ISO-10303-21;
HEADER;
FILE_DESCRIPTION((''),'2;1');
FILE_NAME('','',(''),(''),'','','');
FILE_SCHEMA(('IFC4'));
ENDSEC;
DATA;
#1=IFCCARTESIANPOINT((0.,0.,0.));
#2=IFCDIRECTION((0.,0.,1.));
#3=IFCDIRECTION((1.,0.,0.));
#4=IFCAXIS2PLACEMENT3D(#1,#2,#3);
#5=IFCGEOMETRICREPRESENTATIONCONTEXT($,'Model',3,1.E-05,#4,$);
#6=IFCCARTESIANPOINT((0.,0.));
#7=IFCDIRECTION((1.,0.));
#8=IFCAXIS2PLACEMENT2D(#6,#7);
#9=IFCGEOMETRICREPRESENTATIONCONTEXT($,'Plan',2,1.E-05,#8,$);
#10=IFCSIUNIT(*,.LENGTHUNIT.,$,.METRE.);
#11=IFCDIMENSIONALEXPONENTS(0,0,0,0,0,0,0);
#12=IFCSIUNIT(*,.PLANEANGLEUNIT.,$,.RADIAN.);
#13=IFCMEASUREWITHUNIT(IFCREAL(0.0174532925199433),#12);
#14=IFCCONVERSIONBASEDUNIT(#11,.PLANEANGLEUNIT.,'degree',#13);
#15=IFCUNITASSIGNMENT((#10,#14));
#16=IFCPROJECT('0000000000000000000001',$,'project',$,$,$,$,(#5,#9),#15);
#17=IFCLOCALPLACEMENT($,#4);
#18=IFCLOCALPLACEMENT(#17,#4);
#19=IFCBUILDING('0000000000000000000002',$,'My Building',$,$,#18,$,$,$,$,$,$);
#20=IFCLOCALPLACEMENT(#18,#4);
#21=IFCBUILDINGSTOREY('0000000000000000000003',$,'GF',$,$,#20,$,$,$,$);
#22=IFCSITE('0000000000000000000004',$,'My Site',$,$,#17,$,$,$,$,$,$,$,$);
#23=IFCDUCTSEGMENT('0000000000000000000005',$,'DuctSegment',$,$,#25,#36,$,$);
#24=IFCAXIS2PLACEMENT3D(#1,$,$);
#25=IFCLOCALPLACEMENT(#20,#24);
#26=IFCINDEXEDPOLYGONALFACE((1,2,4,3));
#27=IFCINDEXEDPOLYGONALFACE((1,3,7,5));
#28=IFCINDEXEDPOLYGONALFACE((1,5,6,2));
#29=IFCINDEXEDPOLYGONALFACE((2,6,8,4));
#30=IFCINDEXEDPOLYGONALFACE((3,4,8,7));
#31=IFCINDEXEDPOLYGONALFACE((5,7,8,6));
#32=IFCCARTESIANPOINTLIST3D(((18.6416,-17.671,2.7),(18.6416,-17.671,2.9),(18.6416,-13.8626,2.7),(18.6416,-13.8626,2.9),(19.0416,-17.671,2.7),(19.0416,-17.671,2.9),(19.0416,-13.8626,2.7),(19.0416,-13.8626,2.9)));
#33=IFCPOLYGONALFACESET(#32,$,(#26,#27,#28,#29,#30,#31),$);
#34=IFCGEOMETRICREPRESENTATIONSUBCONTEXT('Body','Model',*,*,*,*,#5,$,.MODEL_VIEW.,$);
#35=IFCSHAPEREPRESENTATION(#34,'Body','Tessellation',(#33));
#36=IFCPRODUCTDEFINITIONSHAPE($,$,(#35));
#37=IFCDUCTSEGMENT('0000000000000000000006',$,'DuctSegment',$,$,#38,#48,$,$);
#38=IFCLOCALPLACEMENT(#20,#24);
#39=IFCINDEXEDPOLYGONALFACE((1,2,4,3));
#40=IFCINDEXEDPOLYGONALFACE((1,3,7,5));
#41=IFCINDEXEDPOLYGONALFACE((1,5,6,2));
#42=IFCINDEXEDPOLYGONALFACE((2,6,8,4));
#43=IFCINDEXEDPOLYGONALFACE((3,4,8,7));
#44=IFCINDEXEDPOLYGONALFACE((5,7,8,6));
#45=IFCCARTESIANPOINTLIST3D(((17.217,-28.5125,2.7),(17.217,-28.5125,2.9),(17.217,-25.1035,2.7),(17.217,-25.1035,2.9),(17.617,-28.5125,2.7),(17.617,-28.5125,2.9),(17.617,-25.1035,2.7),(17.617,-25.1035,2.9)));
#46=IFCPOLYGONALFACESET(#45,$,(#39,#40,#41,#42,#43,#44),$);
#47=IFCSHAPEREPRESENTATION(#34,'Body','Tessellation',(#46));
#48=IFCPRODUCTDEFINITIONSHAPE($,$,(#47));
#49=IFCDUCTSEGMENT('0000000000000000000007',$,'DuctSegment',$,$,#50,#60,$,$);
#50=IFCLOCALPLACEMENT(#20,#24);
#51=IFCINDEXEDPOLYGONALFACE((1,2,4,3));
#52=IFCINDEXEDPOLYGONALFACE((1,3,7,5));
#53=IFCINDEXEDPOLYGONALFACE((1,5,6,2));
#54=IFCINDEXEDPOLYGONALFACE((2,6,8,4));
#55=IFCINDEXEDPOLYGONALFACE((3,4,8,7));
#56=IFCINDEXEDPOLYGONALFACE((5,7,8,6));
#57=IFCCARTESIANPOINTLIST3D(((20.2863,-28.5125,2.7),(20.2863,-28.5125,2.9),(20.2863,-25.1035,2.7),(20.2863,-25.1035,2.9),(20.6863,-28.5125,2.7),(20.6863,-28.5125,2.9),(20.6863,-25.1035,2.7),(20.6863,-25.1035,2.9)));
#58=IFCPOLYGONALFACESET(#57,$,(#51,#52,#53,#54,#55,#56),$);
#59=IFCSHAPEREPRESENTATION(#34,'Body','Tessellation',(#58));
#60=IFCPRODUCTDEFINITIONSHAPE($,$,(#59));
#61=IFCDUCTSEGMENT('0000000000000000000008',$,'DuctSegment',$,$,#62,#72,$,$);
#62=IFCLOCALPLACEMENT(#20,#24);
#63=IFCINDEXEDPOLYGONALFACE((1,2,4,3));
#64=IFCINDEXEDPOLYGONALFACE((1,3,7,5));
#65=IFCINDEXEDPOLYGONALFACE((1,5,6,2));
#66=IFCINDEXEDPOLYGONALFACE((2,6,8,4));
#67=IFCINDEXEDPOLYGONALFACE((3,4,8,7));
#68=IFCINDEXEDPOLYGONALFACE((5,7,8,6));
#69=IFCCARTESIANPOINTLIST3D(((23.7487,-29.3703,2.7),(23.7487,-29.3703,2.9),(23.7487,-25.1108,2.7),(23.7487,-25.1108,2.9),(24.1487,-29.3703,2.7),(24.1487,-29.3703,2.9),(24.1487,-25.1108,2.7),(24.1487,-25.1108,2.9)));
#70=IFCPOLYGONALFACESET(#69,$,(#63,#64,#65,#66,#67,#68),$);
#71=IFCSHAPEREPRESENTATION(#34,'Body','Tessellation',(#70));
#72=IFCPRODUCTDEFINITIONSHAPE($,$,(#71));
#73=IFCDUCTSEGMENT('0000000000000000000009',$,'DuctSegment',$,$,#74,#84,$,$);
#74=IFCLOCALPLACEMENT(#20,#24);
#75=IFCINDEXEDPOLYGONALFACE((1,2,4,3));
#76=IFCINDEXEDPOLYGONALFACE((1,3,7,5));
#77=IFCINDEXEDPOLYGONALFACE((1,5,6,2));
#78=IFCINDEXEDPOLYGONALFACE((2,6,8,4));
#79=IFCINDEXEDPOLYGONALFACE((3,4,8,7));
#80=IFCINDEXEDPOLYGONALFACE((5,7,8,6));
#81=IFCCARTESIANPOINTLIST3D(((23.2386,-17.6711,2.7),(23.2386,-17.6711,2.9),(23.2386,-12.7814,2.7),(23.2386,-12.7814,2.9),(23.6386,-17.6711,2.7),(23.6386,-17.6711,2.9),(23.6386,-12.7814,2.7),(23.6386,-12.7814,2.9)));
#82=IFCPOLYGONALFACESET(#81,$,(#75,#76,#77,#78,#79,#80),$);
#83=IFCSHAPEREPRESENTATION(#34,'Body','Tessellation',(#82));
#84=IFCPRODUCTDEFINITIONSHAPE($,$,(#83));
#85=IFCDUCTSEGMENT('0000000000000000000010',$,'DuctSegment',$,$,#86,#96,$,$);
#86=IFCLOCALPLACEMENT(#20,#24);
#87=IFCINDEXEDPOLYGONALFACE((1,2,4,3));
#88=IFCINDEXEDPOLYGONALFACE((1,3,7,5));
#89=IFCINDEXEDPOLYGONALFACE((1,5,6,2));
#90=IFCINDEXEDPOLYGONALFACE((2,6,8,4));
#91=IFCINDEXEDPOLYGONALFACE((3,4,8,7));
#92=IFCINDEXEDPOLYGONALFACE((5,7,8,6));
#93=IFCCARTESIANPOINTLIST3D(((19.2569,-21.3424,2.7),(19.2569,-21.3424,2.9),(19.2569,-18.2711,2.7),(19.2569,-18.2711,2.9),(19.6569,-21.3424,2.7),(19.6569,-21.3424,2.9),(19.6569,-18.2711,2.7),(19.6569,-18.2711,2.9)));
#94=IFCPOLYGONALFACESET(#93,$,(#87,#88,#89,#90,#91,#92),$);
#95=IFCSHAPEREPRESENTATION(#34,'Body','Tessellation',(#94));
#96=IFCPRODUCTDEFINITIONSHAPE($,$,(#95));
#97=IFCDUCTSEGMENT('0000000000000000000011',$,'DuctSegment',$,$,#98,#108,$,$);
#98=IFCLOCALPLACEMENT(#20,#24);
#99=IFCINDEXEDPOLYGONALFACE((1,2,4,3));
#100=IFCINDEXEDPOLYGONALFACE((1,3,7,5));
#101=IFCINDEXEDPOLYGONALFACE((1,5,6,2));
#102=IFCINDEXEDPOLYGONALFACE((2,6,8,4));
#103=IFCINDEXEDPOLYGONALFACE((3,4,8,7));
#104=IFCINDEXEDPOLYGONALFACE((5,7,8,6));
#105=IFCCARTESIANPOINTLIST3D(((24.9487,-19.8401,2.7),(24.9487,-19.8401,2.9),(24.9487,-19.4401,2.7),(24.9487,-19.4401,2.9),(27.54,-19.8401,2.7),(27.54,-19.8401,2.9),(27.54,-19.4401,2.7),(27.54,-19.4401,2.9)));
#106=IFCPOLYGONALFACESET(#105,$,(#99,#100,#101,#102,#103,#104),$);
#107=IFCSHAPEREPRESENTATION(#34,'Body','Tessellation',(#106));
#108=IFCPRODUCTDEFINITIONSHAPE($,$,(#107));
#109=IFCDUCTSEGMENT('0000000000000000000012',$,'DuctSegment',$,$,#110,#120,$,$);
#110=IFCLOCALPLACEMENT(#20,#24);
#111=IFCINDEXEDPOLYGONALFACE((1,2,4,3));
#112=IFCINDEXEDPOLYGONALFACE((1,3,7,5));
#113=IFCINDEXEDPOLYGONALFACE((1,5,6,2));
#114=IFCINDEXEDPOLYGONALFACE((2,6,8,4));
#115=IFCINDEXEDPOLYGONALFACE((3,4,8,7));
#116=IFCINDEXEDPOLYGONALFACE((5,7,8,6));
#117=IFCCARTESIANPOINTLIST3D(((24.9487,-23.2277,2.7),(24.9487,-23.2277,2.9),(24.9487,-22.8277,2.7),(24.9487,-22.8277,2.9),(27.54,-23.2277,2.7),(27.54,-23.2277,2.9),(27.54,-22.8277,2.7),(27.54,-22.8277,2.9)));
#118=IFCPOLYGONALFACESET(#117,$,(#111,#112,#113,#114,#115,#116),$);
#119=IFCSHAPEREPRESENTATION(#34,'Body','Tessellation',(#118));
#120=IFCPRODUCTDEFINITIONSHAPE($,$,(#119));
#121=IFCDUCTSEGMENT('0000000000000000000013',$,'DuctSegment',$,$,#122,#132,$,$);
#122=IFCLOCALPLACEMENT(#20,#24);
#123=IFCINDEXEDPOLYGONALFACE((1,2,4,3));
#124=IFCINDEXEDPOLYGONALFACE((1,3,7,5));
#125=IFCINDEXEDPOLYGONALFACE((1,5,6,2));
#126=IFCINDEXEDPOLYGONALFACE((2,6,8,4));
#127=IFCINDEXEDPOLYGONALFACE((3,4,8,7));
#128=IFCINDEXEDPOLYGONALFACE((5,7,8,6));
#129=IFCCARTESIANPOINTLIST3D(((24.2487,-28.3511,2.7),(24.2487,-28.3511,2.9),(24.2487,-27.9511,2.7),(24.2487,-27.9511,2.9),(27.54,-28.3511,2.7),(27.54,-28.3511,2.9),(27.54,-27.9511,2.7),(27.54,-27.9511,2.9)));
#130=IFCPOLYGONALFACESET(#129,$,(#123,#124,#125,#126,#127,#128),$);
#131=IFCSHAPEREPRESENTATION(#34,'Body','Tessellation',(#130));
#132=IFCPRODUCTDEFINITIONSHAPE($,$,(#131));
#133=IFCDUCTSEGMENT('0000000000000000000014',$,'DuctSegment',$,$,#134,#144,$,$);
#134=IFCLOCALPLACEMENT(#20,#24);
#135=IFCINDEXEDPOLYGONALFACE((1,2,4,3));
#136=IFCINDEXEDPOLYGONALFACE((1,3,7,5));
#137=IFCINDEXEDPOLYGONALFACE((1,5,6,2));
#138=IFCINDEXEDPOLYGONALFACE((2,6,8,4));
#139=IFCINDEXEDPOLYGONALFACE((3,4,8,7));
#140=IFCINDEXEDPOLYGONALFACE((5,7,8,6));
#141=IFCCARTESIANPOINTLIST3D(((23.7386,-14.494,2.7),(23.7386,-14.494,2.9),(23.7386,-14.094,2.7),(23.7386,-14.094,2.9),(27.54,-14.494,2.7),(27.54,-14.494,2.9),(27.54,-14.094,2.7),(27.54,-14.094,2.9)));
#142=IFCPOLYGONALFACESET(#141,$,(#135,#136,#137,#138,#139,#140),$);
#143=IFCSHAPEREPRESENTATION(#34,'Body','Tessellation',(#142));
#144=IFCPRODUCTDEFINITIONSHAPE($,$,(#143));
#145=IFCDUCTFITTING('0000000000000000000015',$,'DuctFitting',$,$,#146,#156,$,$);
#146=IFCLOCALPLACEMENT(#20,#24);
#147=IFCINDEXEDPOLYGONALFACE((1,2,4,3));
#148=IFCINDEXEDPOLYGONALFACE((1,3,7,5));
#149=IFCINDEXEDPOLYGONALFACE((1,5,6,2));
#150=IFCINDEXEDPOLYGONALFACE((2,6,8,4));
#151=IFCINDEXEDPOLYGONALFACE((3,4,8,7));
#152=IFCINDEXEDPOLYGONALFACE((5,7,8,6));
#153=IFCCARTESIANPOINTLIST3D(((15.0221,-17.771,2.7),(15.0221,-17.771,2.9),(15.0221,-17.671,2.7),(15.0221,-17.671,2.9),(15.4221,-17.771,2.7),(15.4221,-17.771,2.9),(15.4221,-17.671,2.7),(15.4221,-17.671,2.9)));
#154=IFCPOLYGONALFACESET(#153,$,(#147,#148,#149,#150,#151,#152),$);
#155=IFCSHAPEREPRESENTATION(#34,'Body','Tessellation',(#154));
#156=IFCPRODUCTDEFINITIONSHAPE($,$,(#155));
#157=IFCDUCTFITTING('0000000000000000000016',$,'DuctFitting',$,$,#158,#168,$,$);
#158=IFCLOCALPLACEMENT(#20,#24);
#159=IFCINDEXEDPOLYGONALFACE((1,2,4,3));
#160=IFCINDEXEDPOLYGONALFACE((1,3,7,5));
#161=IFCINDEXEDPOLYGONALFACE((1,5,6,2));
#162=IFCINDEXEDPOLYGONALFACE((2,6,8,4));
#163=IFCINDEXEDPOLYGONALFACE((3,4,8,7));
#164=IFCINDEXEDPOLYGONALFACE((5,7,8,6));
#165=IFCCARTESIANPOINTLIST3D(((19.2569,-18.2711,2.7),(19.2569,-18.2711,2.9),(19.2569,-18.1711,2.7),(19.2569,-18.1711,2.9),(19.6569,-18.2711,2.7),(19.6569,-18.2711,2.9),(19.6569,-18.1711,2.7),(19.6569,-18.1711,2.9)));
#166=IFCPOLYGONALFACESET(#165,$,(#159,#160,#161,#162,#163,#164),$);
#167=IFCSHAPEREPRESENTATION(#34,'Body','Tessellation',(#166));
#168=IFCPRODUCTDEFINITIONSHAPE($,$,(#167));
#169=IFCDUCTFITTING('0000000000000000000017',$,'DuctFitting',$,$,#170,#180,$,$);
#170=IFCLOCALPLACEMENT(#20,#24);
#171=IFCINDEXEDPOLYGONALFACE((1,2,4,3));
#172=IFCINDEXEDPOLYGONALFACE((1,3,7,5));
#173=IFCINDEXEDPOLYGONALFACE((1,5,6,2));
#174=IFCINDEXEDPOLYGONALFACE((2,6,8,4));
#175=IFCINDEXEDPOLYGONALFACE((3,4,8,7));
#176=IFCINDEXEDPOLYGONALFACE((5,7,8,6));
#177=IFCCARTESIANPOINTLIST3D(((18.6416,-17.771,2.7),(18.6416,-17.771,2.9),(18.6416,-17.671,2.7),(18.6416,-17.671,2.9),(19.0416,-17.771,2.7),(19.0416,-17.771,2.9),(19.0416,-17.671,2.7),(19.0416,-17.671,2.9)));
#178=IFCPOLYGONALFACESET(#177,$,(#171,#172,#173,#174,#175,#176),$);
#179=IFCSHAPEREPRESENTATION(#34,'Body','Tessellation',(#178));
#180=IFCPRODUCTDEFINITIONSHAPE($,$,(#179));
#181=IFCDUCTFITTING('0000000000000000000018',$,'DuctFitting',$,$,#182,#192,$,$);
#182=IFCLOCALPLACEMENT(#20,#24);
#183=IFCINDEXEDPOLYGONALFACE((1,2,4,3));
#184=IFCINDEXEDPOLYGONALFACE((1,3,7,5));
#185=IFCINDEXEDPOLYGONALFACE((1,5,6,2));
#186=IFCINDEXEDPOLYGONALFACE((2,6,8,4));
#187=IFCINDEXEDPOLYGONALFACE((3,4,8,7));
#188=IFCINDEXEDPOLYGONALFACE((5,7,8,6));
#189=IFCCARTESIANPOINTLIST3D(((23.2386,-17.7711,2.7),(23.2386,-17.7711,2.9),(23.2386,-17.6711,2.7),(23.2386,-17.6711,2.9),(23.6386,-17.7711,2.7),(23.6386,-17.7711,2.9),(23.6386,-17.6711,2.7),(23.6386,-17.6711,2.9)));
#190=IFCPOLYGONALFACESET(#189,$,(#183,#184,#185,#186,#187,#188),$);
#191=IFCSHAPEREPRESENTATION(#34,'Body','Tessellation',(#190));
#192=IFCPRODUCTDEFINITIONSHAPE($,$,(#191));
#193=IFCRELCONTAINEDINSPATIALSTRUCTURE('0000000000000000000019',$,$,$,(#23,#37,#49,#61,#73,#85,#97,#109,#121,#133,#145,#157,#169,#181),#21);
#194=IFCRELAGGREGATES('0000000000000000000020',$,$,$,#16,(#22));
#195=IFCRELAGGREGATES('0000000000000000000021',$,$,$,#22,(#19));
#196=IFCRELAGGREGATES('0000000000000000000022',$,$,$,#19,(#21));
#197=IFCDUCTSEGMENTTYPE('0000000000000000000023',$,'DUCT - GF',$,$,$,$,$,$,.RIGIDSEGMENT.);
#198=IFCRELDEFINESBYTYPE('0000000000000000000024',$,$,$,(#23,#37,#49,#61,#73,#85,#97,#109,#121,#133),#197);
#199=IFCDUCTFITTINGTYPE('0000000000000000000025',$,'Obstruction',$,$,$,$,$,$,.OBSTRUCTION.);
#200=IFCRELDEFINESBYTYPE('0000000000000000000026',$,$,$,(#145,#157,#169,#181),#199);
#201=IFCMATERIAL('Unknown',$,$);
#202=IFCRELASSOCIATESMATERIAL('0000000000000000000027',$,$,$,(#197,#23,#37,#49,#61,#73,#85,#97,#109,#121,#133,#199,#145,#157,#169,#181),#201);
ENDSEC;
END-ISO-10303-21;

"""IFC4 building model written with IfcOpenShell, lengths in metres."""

from ifc_helpers import new_model, entity, si_unit, converted_unit, frame, origin_with_axes, origin_2d_with_axis, place, context, subcontext, project, spatial, rectangle, extrude, material, material_profile, profile_set, profile_usage, type_object, element, save


model = new_model("IFC4")

# Units and contexts
model_context = context("Model", 3, precision=1e-05, world=origin_with_axes())
plan_context = context("Plan", 2, precision=1e-05, world=origin_2d_with_axis())
body_context_1 = subcontext(model_context, "Body", "Model", "MODEL_VIEW")
ifc_project = project(units=[si_unit("LENGTHUNIT", "METRE"), converted_unit("PLANEANGLEUNIT", "degree", entity("IfcReal", 0.0174532925199433), si_unit("PLANEANGLEUNIT", "RADIAN"), dimensions=[0, 0, 0, 0, 0, 0, 0])], contexts=[model_context, plan_context])

# Site, building, storey
site_placement = place(None, origin_with_axes())
site = spatial("IfcSite", under=ifc_project, at=site_placement, Name="My Site")
building_placement = place(site_placement, origin_with_axes())
building = spatial("IfcBuilding", under=site, at=building_placement, Name="My Building")
storey_placement = place(building_placement, origin_with_axes())
storey = spatial("IfcBuildingStorey", under=building, at=storey_placement, Name="GF")

# Shared definitions
ifc_material = material(Name="Unknown")

# Duct segments
ifc_material_profile_1 = material_profile(ifc_material, rectangle(XDim=0.4, YDim=0.2))
ifc_profile_set_1 = profile_set([ifc_material_profile_1])
duct_segment_type = type_object("IfcDuctSegmentType", Name="DUCT - GF", PredefinedType="RIGIDSEGMENT", material=ifc_profile_set_1)
ifc_profile_usage_1 = profile_usage(ifc_profile_set_1, cardinal=5)
duct_segment_1_placement = place(storey_placement, frame((18.8416, -13.8626, 2.8), z_axis=(0.0, -1.0, 0.0), x_axis=(1.0, 0.0, 0.0)))
element("IfcDuctSegment", 1, at=duct_segment_1_placement, inside=storey, type_object=duct_segment_type, material=ifc_profile_usage_1, Name="DuctSegment", context=body_context_1, shape_type="SweptSolid", body=[
    extrude(rectangle(XDim=0.4, YDim=0.2), origin_with_axes(), (0.0, 0.0, 1.0), 3.8084),
])
ifc_profile_usage_2 = profile_usage(ifc_profile_set_1, cardinal=5)
duct_segment_2_placement = place(storey_placement, frame((17.417, -28.5125, 2.8), z_axis=(0.0, 1.0, 0.0), x_axis=(-1.0, 0.0, 0.0)))
element("IfcDuctSegment", 2, at=duct_segment_2_placement, inside=storey, type_object=duct_segment_type, material=ifc_profile_usage_2, Name="DuctSegment", context=body_context_1, shape_type="SweptSolid", body=[
    extrude(rectangle(XDim=0.4, YDim=0.2), origin_with_axes(), (0.0, 0.0, 1.0), 3.409),
])
ifc_profile_usage_3 = profile_usage(ifc_profile_set_1, cardinal=5)
duct_segment_3_placement = place(storey_placement, frame((20.4863, -28.5125, 2.8), z_axis=(0.0, 1.0, 0.0), x_axis=(-1.0, 0.0, 0.0)))
element("IfcDuctSegment", 3, at=duct_segment_3_placement, inside=storey, type_object=duct_segment_type, material=ifc_profile_usage_3, Name="DuctSegment", context=body_context_1, shape_type="SweptSolid", body=[
    extrude(rectangle(XDim=0.4, YDim=0.2), origin_with_axes(), (0.0, 0.0, 1.0), 3.409),
])
ifc_profile_usage_4 = profile_usage(ifc_profile_set_1, cardinal=5)
duct_segment_4_placement = place(storey_placement, frame((23.9487, -29.3703, 2.8), z_axis=(0.0, 1.0, 0.0), x_axis=(-1.0, 0.0, 0.0)))
element("IfcDuctSegment", 4, at=duct_segment_4_placement, inside=storey, type_object=duct_segment_type, material=ifc_profile_usage_4, Name="DuctSegment", context=body_context_1, shape_type="SweptSolid", body=[
    extrude(rectangle(XDim=0.4, YDim=0.2), origin_with_axes(), (0.0, 0.0, 1.0), 4.2596),
])
ifc_profile_usage_5 = profile_usage(ifc_profile_set_1, cardinal=5)
duct_segment_5_placement = place(storey_placement, frame((23.4386, -12.7814, 2.8), z_axis=(0.0, -1.0, 0.0), x_axis=(1.0, 0.0, 0.0)))
element("IfcDuctSegment", 5, at=duct_segment_5_placement, inside=storey, type_object=duct_segment_type, material=ifc_profile_usage_5, Name="DuctSegment", context=body_context_1, shape_type="SweptSolid", body=[
    extrude(rectangle(XDim=0.4, YDim=0.2), origin_with_axes(), (0.0, 0.0, 1.0), 4.8897),
])
ifc_profile_usage_6 = profile_usage(ifc_profile_set_1, cardinal=5)
duct_segment_6_placement = place(storey_placement, frame((19.4569, -21.3424, 2.8), z_axis=(0.0, 1.0, 0.0), x_axis=(-1.0, 0.0, 0.0)))
element("IfcDuctSegment", 6, at=duct_segment_6_placement, inside=storey, type_object=duct_segment_type, material=ifc_profile_usage_6, Name="DuctSegment", context=body_context_1, shape_type="SweptSolid", body=[
    extrude(rectangle(XDim=0.4, YDim=0.2), origin_with_axes(), (0.0, 0.0, 1.0), 3.0713),
])
ifc_profile_usage_7 = profile_usage(ifc_profile_set_1, cardinal=5)
duct_segment_7_placement = place(storey_placement, frame((27.54, -19.6401, 2.8), z_axis=(-1.0, 0.0, 0.0), x_axis=(0.0, -1.0, 0.0)))
element("IfcDuctSegment", 7, at=duct_segment_7_placement, inside=storey, type_object=duct_segment_type, material=ifc_profile_usage_7, Name="DuctSegment", context=body_context_1, shape_type="SweptSolid", body=[
    extrude(rectangle(XDim=0.4, YDim=0.2), origin_with_axes(), (0.0, 0.0, 1.0), 2.5913),
])
ifc_profile_usage_8 = profile_usage(ifc_profile_set_1, cardinal=5)
duct_segment_8_placement = place(storey_placement, frame((27.54, -23.0277, 2.8), z_axis=(-1.0, 0.0, 0.0), x_axis=(0.0, -1.0, 0.0)))
element("IfcDuctSegment", 8, at=duct_segment_8_placement, inside=storey, type_object=duct_segment_type, material=ifc_profile_usage_8, Name="DuctSegment", context=body_context_1, shape_type="SweptSolid", body=[
    extrude(rectangle(XDim=0.4, YDim=0.2), origin_with_axes(), (0.0, 0.0, 1.0), 2.5913),
])
ifc_profile_usage_9 = profile_usage(ifc_profile_set_1, cardinal=5)
duct_segment_9_placement = place(storey_placement, frame((27.54, -28.1511, 2.8), z_axis=(-1.0, 0.0, 0.0), x_axis=(0.0, -1.0, 0.0)))
element("IfcDuctSegment", 9, at=duct_segment_9_placement, inside=storey, type_object=duct_segment_type, material=ifc_profile_usage_9, Name="DuctSegment", context=body_context_1, shape_type="SweptSolid", body=[
    extrude(rectangle(XDim=0.4, YDim=0.2), origin_with_axes(), (0.0, 0.0, 1.0), 3.2913),
])
ifc_profile_usage_10 = profile_usage(ifc_profile_set_1, cardinal=5)
duct_segment_10_placement = place(storey_placement, frame((27.54, -14.294, 2.8), z_axis=(-1.0, 0.0, 0.0), x_axis=(0.0, -1.0, 0.0)))
element("IfcDuctSegment", 10, at=duct_segment_10_placement, inside=storey, type_object=duct_segment_type, material=ifc_profile_usage_10, Name="DuctSegment", context=body_context_1, shape_type="SweptSolid", body=[
    extrude(rectangle(XDim=0.4, YDim=0.2), origin_with_axes(), (0.0, 0.0, 1.0), 3.8014),
])

# Duct fittings
ifc_material_profile_2 = material_profile(ifc_material, rectangle(XDim=0.4, YDim=0.2))
ifc_profile_set_2 = profile_set([ifc_material_profile_2])
ifc_profile_usage_11 = profile_usage(ifc_profile_set_2, cardinal=5)
duct_fitting_type = type_object("IfcDuctFittingType", Name="Obstruction", PredefinedType="OBSTRUCTION", material=ifc_profile_set_2)
duct_fitting_1_placement = place(storey_placement, frame((15.2221, -17.671, 2.8), z_axis=(0.0, -1.0, 0.0), x_axis=(1.0, 0.0, 0.0)))
element("IfcDuctFitting", 11, at=duct_fitting_1_placement, inside=storey, type_object=duct_fitting_type, material=ifc_profile_usage_11, Name="DuctFitting", context=body_context_1, shape_type="SweptSolid", body=[
    extrude(rectangle(XDim=0.4, YDim=0.2), origin_with_axes(), (0.0, 0.0, 1.0), 0.1),
])
ifc_profile_usage_12 = profile_usage(ifc_profile_set_2, cardinal=5)
duct_fitting_2_placement = place(storey_placement, frame((19.4569, -18.2711, 2.8), z_axis=(0.0, 1.0, 0.0), x_axis=(-1.0, 0.0, 0.0)))
element("IfcDuctFitting", 12, at=duct_fitting_2_placement, inside=storey, type_object=duct_fitting_type, material=ifc_profile_usage_12, Name="DuctFitting", context=body_context_1, shape_type="SweptSolid", body=[
    extrude(rectangle(XDim=0.4, YDim=0.2), origin_with_axes(), (0.0, 0.0, 1.0), 0.1),
])
ifc_profile_usage_13 = profile_usage(ifc_profile_set_2, cardinal=5)
duct_fitting_3_placement = place(storey_placement, frame((18.8416, -17.671, 2.8), z_axis=(0.0, -1.0, 0.0), x_axis=(1.0, 0.0, 0.0)))
element("IfcDuctFitting", 13, at=duct_fitting_3_placement, inside=storey, type_object=duct_fitting_type, material=ifc_profile_usage_13, Name="DuctFitting", context=body_context_1, shape_type="SweptSolid", body=[
    extrude(rectangle(XDim=0.4, YDim=0.2), origin_with_axes(), (0.0, 0.0, 1.0), 0.1),
])
ifc_profile_usage_14 = profile_usage(ifc_profile_set_2, cardinal=5)
duct_fitting_4_placement = place(storey_placement, frame((23.4386, -17.6711, 2.8), z_axis=(0.0, -1.0, 0.0), x_axis=(1.0, 0.0, 0.0)))
element("IfcDuctFitting", 14, at=duct_fitting_4_placement, inside=storey, type_object=duct_fitting_type, material=ifc_profile_usage_14, Name="DuctFitting", context=body_context_1, shape_type="SweptSolid", body=[
    extrude(rectangle(XDim=0.4, YDim=0.2), origin_with_axes(), (0.0, 0.0, 1.0), 0.1),
])

save(model, "model.ifc")
